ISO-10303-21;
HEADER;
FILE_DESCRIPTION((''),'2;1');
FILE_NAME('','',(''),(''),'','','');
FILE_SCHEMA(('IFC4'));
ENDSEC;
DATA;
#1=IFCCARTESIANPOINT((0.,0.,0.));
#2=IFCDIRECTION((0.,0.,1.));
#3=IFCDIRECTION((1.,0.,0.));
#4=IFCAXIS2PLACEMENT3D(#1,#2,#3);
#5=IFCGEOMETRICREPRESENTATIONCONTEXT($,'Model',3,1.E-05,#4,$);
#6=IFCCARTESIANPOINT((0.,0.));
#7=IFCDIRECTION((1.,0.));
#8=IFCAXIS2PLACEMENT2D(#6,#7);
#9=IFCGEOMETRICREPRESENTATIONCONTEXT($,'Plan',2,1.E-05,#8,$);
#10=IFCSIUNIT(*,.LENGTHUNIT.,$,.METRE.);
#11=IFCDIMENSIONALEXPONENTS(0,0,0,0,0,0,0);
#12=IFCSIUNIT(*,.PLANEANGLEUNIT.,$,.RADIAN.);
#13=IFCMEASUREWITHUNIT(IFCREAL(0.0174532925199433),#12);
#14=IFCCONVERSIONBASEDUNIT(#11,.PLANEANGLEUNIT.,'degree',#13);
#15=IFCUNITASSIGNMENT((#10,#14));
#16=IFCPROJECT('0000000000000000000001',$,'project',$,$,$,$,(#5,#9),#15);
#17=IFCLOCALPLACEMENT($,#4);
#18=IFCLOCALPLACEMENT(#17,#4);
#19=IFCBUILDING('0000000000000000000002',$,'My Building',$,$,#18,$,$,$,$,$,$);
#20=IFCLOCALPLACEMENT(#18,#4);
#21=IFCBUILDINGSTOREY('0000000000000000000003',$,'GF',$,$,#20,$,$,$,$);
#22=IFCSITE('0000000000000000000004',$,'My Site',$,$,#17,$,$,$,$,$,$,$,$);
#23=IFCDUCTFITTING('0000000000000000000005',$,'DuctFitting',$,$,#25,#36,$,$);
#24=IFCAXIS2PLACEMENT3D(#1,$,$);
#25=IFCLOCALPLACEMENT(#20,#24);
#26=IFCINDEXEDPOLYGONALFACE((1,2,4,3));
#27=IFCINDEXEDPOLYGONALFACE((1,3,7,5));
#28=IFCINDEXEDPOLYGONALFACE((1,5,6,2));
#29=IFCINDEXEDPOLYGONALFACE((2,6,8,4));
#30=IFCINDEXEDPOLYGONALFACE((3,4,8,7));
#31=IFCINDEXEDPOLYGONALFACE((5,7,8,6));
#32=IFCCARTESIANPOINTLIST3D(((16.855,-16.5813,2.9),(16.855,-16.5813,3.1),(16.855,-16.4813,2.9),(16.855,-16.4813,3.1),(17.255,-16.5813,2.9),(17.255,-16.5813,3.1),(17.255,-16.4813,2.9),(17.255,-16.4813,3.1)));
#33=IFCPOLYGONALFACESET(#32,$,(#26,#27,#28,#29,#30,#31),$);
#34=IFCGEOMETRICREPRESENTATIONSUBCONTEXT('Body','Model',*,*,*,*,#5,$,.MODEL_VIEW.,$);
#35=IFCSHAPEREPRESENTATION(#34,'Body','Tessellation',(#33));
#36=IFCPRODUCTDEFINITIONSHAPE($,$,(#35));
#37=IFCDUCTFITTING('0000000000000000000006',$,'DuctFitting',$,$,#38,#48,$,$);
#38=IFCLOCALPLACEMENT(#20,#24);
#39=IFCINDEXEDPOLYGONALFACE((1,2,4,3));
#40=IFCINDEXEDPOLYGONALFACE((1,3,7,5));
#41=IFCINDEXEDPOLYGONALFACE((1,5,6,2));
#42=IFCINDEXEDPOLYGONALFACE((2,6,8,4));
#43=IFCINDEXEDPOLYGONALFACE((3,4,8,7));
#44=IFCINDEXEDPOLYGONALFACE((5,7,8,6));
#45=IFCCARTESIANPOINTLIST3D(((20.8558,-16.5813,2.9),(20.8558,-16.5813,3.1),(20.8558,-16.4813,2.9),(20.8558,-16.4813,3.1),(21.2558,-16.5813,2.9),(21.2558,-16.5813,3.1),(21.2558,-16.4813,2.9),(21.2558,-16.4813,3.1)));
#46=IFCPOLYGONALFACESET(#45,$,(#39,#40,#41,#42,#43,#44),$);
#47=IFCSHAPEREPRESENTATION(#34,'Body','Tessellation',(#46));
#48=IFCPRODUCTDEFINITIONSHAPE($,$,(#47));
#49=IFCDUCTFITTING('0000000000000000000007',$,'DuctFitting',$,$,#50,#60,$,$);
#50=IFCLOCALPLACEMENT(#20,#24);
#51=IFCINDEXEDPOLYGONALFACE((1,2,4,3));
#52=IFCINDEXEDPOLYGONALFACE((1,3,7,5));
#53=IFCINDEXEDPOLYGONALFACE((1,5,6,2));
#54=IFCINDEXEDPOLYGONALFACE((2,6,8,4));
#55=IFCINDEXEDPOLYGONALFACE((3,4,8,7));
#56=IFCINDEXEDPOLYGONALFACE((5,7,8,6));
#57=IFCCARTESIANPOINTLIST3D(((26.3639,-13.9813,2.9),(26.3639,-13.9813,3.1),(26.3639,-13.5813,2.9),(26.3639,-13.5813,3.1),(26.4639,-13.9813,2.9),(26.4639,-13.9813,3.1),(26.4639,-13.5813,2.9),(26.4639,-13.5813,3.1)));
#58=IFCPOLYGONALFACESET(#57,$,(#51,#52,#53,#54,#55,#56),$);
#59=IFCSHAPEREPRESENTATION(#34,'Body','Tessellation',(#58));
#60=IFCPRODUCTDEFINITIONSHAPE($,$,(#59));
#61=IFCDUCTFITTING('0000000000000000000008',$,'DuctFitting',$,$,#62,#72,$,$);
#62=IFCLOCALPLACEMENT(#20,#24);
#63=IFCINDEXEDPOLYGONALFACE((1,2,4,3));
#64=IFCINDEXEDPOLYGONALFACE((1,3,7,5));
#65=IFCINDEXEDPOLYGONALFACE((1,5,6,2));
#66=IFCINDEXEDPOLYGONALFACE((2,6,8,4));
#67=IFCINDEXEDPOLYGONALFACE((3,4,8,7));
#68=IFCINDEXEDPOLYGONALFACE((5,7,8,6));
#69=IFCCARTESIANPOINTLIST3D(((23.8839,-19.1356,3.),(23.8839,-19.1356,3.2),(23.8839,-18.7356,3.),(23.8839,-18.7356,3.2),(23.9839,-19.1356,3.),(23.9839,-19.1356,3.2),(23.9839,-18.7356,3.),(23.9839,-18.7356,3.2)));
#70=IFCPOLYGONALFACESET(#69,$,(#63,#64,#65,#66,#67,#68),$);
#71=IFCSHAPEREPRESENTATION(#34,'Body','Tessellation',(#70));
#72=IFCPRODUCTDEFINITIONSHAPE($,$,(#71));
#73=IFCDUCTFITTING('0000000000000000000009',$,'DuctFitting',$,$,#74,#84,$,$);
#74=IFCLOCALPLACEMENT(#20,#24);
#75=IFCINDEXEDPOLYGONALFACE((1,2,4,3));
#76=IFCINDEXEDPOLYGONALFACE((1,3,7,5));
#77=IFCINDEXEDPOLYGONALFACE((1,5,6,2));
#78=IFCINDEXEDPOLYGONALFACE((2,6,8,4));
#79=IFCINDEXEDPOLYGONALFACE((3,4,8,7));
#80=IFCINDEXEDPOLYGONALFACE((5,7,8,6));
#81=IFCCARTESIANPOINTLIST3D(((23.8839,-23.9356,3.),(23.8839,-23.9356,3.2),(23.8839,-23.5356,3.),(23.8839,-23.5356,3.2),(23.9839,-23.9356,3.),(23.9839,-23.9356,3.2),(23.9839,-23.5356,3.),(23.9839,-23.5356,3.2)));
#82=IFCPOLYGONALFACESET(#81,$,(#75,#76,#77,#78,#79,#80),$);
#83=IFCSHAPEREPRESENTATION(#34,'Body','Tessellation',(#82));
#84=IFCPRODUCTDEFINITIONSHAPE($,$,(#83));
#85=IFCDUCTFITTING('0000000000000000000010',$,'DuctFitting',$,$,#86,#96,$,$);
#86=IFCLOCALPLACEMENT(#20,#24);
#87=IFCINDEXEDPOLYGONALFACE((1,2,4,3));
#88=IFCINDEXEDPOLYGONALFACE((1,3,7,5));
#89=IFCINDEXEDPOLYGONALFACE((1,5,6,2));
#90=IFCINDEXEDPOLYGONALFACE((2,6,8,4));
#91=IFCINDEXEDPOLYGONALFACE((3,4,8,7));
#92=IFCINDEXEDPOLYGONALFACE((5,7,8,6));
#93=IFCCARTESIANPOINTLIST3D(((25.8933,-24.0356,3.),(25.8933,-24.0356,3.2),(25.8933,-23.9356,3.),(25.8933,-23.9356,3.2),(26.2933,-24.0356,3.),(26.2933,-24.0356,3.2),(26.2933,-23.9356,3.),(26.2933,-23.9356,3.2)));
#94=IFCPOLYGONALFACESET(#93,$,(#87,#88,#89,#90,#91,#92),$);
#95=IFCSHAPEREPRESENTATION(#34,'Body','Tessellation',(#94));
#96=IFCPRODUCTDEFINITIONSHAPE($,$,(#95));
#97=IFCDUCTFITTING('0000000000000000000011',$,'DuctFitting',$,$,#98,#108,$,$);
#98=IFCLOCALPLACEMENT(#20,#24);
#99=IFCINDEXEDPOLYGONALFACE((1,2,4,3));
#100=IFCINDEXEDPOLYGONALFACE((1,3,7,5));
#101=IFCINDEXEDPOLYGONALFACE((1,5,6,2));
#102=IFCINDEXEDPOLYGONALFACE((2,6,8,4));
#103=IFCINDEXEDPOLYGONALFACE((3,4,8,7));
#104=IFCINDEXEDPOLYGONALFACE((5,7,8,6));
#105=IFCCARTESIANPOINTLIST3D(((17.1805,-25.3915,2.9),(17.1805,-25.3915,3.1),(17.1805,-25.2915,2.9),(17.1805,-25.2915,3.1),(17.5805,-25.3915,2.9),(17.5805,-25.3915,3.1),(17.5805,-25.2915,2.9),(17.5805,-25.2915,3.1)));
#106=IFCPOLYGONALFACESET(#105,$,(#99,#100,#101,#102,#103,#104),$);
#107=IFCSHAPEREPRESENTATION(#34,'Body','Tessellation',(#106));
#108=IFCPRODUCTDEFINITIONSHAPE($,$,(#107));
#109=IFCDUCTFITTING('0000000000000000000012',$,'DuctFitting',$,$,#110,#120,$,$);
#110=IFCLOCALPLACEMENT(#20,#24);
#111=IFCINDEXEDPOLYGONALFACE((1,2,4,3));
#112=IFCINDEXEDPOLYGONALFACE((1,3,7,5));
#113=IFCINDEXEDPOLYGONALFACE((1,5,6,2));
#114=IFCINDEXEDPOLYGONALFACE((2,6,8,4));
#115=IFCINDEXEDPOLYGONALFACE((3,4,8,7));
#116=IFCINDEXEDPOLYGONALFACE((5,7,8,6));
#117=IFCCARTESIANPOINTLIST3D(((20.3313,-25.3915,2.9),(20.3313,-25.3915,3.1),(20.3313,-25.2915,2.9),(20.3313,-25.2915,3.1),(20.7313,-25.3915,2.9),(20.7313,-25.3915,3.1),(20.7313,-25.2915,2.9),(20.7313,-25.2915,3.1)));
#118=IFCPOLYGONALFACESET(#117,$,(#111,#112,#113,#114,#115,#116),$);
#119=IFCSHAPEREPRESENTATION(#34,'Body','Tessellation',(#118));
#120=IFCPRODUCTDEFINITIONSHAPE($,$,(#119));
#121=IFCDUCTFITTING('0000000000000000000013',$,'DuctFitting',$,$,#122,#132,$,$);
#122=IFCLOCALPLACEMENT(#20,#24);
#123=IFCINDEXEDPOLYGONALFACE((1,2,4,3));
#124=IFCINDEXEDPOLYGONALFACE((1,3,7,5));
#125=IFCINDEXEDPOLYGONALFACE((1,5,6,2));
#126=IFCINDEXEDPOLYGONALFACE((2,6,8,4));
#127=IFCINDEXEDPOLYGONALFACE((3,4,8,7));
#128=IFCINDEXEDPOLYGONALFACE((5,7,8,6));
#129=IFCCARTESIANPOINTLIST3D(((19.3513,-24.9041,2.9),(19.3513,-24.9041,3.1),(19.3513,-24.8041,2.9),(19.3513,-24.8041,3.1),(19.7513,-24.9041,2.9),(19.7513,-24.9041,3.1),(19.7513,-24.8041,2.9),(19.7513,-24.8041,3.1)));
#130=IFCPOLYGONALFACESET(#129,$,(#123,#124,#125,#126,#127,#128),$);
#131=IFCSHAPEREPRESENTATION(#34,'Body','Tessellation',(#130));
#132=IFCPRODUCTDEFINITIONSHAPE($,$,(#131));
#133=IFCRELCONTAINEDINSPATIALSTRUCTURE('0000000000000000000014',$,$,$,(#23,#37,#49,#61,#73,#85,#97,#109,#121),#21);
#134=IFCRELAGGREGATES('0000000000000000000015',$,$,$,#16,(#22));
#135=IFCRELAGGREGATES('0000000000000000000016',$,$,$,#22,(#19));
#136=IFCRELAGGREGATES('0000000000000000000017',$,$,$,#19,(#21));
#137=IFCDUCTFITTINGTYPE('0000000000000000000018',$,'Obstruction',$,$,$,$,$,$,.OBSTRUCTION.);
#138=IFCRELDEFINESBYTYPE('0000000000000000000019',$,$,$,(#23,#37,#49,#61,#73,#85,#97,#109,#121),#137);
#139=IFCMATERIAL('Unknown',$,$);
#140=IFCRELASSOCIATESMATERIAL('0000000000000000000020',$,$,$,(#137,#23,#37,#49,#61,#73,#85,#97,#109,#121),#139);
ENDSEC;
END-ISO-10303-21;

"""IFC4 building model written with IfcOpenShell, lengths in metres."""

from ifc_helpers import new_model, entity, si_unit, converted_unit, frame, origin_with_axes, origin_2d_with_axis, place, context, subcontext, project, spatial, rectangle, extrude, material, material_profile, profile_set, profile_usage, type_object, element, save


model = new_model("IFC4")

# Units and contexts
model_context = context("Model", 3, precision=1e-05, world=origin_with_axes())
plan_context = context("Plan", 2, precision=1e-05, world=origin_2d_with_axis())
body_context_1 = subcontext(model_context, "Body", "Model", "MODEL_VIEW")
ifc_project = project(units=[si_unit("LENGTHUNIT", "METRE"), converted_unit("PLANEANGLEUNIT", "degree", entity("IfcReal", 0.0174532925199433), si_unit("PLANEANGLEUNIT", "RADIAN"), dimensions=[0, 0, 0, 0, 0, 0, 0])], contexts=[model_context, plan_context])

# Site, building, storey
site_placement = place(None, origin_with_axes())
site = spatial("IfcSite", under=ifc_project, at=site_placement, Name="My Site")
building_placement = place(site_placement, origin_with_axes())
building = spatial("IfcBuilding", under=site, at=building_placement, Name="My Building")
storey_placement = place(building_placement, origin_with_axes())
storey = spatial("IfcBuildingStorey", under=building, at=storey_placement, Name="GF")

# Shared definitions
ifc_material = material(Name="Unknown")

# Duct fittings
ifc_material_profile_1 = material_profile(ifc_material, rectangle(XDim=0.4, YDim=0.2))
ifc_profile_set_1 = profile_set([ifc_material_profile_1])
ifc_profile_usage_1 = profile_usage(ifc_profile_set_1, cardinal=5)
duct_fitting_type = type_object("IfcDuctFittingType", Name="Obstruction", PredefinedType="OBSTRUCTION", material=ifc_profile_set_1)
duct_fitting_1_placement = place(storey_placement, frame((17.055, -16.4813, 3.0), z_axis=(0.0, -1.0, 0.0), x_axis=(1.0, 0.0, 0.0)))
element("IfcDuctFitting", 1, at=duct_fitting_1_placement, inside=storey, type_object=duct_fitting_type, material=ifc_profile_usage_1, Name="DuctFitting", context=body_context_1, shape_type="SweptSolid", body=[
    extrude(rectangle(XDim=0.4, YDim=0.2), origin_with_axes(), (0.0, 0.0, 1.0), 0.1),
])
ifc_profile_usage_2 = profile_usage(ifc_profile_set_1, cardinal=5)
duct_fitting_2_placement = place(storey_placement, frame((21.0558, -16.4813, 3.0), z_axis=(0.0, -1.0, 0.0), x_axis=(1.0, 0.0, 0.0)))
element("IfcDuctFitting", 2, at=duct_fitting_2_placement, inside=storey, type_object=duct_fitting_type, material=ifc_profile_usage_2, Name="DuctFitting", context=body_context_1, shape_type="SweptSolid", body=[
    extrude(rectangle(XDim=0.4, YDim=0.2), origin_with_axes(), (0.0, 0.0, 1.0), 0.1),
])
ifc_profile_usage_3 = profile_usage(ifc_profile_set_1, cardinal=5)
duct_fitting_3_placement = place(storey_placement, frame((26.3639, -13.7813, 3.0), z_axis=(1.0, 0.0, 0.0), x_axis=(0.0, 1.0, 0.0)))
element("IfcDuctFitting", 3, at=duct_fitting_3_placement, inside=storey, type_object=duct_fitting_type, material=ifc_profile_usage_3, Name="DuctFitting", context=body_context_1, shape_type="SweptSolid", body=[
    extrude(rectangle(XDim=0.4, YDim=0.2), origin_with_axes(), (0.0, 0.0, 1.0), 0.1),
])
ifc_profile_usage_4 = profile_usage(ifc_profile_set_1, cardinal=5)
duct_fitting_4_placement = place(storey_placement, frame((23.8839, -18.9356, 3.1), z_axis=(1.0, 0.0, 0.0), x_axis=(0.0, 1.0, 0.0)))
element("IfcDuctFitting", 4, at=duct_fitting_4_placement, inside=storey, type_object=duct_fitting_type, material=ifc_profile_usage_4, Name="DuctFitting", context=body_context_1, shape_type="SweptSolid", body=[
    extrude(rectangle(XDim=0.4, YDim=0.2), origin_with_axes(), (0.0, 0.0, 1.0), 0.1),
])
ifc_profile_usage_5 = profile_usage(ifc_profile_set_1, cardinal=5)
duct_fitting_5_placement = place(storey_placement, frame((23.8839, -23.7356, 3.1), z_axis=(1.0, 0.0, 0.0), x_axis=(0.0, 1.0, 0.0)))
element("IfcDuctFitting", 5, at=duct_fitting_5_placement, inside=storey, type_object=duct_fitting_type, material=ifc_profile_usage_5, Name="DuctFitting", context=body_context_1, shape_type="SweptSolid", body=[
    extrude(rectangle(XDim=0.4, YDim=0.2), origin_with_axes(), (0.0, 0.0, 1.0), 0.1),
])
ifc_profile_usage_6 = profile_usage(ifc_profile_set_1, cardinal=5)
duct_fitting_6_placement = place(storey_placement, frame((26.0933, -23.9356, 3.1), z_axis=(0.0, -1.0, 0.000001), x_axis=(1.0, 0.0, 0.0)))
element("IfcDuctFitting", 6, at=duct_fitting_6_placement, inside=storey, type_object=duct_fitting_type, material=ifc_profile_usage_6, Name="DuctFitting", context=body_context_1, shape_type="SweptSolid", body=[
    extrude(rectangle(XDim=0.4, YDim=0.2), origin_with_axes(), (0.0, 0.0, 1.0), 0.1),
])
ifc_profile_usage_7 = profile_usage(ifc_profile_set_1, cardinal=5)
duct_fitting_7_placement = place(storey_placement, frame((17.3805, -25.2915, 3.0), z_axis=(0.0, -1.0, 0.0), x_axis=(1.0, 0.0, 0.0)))
element("IfcDuctFitting", 7, at=duct_fitting_7_placement, inside=storey, type_object=duct_fitting_type, material=ifc_profile_usage_7, Name="DuctFitting", context=body_context_1, shape_type="SweptSolid", body=[
    extrude(rectangle(XDim=0.4, YDim=0.2), origin_with_axes(), (0.0, 0.0, 1.0), 0.1),
])
ifc_profile_usage_8 = profile_usage(ifc_profile_set_1, cardinal=5)
duct_fitting_8_placement = place(storey_placement, frame((20.5313, -25.2915, 3.0), z_axis=(0.0, -1.0, 0.0), x_axis=(1.0, 0.0, 0.0)))
element("IfcDuctFitting", 8, at=duct_fitting_8_placement, inside=storey, type_object=duct_fitting_type, material=ifc_profile_usage_8, Name="DuctFitting", context=body_context_1, shape_type="SweptSolid", body=[
    extrude(rectangle(XDim=0.4, YDim=0.2), origin_with_axes(), (0.0, 0.0, 1.0), 0.1),
])
ifc_profile_usage_9 = profile_usage(ifc_profile_set_1, cardinal=5)
duct_fitting_9_placement = place(storey_placement, frame((19.5513, -24.8041, 3.0), z_axis=(0.0, -1.0, 0.0), x_axis=(1.0, 0.0, 0.0)))
element("IfcDuctFitting", 9, at=duct_fitting_9_placement, inside=storey, type_object=duct_fitting_type, material=ifc_profile_usage_9, Name="DuctFitting", context=body_context_1, shape_type="SweptSolid", body=[
    extrude(rectangle(XDim=0.4, YDim=0.2), origin_with_axes(), (0.0, 0.0, 1.0), 0.1),
])

save(model, "model.ifc")
